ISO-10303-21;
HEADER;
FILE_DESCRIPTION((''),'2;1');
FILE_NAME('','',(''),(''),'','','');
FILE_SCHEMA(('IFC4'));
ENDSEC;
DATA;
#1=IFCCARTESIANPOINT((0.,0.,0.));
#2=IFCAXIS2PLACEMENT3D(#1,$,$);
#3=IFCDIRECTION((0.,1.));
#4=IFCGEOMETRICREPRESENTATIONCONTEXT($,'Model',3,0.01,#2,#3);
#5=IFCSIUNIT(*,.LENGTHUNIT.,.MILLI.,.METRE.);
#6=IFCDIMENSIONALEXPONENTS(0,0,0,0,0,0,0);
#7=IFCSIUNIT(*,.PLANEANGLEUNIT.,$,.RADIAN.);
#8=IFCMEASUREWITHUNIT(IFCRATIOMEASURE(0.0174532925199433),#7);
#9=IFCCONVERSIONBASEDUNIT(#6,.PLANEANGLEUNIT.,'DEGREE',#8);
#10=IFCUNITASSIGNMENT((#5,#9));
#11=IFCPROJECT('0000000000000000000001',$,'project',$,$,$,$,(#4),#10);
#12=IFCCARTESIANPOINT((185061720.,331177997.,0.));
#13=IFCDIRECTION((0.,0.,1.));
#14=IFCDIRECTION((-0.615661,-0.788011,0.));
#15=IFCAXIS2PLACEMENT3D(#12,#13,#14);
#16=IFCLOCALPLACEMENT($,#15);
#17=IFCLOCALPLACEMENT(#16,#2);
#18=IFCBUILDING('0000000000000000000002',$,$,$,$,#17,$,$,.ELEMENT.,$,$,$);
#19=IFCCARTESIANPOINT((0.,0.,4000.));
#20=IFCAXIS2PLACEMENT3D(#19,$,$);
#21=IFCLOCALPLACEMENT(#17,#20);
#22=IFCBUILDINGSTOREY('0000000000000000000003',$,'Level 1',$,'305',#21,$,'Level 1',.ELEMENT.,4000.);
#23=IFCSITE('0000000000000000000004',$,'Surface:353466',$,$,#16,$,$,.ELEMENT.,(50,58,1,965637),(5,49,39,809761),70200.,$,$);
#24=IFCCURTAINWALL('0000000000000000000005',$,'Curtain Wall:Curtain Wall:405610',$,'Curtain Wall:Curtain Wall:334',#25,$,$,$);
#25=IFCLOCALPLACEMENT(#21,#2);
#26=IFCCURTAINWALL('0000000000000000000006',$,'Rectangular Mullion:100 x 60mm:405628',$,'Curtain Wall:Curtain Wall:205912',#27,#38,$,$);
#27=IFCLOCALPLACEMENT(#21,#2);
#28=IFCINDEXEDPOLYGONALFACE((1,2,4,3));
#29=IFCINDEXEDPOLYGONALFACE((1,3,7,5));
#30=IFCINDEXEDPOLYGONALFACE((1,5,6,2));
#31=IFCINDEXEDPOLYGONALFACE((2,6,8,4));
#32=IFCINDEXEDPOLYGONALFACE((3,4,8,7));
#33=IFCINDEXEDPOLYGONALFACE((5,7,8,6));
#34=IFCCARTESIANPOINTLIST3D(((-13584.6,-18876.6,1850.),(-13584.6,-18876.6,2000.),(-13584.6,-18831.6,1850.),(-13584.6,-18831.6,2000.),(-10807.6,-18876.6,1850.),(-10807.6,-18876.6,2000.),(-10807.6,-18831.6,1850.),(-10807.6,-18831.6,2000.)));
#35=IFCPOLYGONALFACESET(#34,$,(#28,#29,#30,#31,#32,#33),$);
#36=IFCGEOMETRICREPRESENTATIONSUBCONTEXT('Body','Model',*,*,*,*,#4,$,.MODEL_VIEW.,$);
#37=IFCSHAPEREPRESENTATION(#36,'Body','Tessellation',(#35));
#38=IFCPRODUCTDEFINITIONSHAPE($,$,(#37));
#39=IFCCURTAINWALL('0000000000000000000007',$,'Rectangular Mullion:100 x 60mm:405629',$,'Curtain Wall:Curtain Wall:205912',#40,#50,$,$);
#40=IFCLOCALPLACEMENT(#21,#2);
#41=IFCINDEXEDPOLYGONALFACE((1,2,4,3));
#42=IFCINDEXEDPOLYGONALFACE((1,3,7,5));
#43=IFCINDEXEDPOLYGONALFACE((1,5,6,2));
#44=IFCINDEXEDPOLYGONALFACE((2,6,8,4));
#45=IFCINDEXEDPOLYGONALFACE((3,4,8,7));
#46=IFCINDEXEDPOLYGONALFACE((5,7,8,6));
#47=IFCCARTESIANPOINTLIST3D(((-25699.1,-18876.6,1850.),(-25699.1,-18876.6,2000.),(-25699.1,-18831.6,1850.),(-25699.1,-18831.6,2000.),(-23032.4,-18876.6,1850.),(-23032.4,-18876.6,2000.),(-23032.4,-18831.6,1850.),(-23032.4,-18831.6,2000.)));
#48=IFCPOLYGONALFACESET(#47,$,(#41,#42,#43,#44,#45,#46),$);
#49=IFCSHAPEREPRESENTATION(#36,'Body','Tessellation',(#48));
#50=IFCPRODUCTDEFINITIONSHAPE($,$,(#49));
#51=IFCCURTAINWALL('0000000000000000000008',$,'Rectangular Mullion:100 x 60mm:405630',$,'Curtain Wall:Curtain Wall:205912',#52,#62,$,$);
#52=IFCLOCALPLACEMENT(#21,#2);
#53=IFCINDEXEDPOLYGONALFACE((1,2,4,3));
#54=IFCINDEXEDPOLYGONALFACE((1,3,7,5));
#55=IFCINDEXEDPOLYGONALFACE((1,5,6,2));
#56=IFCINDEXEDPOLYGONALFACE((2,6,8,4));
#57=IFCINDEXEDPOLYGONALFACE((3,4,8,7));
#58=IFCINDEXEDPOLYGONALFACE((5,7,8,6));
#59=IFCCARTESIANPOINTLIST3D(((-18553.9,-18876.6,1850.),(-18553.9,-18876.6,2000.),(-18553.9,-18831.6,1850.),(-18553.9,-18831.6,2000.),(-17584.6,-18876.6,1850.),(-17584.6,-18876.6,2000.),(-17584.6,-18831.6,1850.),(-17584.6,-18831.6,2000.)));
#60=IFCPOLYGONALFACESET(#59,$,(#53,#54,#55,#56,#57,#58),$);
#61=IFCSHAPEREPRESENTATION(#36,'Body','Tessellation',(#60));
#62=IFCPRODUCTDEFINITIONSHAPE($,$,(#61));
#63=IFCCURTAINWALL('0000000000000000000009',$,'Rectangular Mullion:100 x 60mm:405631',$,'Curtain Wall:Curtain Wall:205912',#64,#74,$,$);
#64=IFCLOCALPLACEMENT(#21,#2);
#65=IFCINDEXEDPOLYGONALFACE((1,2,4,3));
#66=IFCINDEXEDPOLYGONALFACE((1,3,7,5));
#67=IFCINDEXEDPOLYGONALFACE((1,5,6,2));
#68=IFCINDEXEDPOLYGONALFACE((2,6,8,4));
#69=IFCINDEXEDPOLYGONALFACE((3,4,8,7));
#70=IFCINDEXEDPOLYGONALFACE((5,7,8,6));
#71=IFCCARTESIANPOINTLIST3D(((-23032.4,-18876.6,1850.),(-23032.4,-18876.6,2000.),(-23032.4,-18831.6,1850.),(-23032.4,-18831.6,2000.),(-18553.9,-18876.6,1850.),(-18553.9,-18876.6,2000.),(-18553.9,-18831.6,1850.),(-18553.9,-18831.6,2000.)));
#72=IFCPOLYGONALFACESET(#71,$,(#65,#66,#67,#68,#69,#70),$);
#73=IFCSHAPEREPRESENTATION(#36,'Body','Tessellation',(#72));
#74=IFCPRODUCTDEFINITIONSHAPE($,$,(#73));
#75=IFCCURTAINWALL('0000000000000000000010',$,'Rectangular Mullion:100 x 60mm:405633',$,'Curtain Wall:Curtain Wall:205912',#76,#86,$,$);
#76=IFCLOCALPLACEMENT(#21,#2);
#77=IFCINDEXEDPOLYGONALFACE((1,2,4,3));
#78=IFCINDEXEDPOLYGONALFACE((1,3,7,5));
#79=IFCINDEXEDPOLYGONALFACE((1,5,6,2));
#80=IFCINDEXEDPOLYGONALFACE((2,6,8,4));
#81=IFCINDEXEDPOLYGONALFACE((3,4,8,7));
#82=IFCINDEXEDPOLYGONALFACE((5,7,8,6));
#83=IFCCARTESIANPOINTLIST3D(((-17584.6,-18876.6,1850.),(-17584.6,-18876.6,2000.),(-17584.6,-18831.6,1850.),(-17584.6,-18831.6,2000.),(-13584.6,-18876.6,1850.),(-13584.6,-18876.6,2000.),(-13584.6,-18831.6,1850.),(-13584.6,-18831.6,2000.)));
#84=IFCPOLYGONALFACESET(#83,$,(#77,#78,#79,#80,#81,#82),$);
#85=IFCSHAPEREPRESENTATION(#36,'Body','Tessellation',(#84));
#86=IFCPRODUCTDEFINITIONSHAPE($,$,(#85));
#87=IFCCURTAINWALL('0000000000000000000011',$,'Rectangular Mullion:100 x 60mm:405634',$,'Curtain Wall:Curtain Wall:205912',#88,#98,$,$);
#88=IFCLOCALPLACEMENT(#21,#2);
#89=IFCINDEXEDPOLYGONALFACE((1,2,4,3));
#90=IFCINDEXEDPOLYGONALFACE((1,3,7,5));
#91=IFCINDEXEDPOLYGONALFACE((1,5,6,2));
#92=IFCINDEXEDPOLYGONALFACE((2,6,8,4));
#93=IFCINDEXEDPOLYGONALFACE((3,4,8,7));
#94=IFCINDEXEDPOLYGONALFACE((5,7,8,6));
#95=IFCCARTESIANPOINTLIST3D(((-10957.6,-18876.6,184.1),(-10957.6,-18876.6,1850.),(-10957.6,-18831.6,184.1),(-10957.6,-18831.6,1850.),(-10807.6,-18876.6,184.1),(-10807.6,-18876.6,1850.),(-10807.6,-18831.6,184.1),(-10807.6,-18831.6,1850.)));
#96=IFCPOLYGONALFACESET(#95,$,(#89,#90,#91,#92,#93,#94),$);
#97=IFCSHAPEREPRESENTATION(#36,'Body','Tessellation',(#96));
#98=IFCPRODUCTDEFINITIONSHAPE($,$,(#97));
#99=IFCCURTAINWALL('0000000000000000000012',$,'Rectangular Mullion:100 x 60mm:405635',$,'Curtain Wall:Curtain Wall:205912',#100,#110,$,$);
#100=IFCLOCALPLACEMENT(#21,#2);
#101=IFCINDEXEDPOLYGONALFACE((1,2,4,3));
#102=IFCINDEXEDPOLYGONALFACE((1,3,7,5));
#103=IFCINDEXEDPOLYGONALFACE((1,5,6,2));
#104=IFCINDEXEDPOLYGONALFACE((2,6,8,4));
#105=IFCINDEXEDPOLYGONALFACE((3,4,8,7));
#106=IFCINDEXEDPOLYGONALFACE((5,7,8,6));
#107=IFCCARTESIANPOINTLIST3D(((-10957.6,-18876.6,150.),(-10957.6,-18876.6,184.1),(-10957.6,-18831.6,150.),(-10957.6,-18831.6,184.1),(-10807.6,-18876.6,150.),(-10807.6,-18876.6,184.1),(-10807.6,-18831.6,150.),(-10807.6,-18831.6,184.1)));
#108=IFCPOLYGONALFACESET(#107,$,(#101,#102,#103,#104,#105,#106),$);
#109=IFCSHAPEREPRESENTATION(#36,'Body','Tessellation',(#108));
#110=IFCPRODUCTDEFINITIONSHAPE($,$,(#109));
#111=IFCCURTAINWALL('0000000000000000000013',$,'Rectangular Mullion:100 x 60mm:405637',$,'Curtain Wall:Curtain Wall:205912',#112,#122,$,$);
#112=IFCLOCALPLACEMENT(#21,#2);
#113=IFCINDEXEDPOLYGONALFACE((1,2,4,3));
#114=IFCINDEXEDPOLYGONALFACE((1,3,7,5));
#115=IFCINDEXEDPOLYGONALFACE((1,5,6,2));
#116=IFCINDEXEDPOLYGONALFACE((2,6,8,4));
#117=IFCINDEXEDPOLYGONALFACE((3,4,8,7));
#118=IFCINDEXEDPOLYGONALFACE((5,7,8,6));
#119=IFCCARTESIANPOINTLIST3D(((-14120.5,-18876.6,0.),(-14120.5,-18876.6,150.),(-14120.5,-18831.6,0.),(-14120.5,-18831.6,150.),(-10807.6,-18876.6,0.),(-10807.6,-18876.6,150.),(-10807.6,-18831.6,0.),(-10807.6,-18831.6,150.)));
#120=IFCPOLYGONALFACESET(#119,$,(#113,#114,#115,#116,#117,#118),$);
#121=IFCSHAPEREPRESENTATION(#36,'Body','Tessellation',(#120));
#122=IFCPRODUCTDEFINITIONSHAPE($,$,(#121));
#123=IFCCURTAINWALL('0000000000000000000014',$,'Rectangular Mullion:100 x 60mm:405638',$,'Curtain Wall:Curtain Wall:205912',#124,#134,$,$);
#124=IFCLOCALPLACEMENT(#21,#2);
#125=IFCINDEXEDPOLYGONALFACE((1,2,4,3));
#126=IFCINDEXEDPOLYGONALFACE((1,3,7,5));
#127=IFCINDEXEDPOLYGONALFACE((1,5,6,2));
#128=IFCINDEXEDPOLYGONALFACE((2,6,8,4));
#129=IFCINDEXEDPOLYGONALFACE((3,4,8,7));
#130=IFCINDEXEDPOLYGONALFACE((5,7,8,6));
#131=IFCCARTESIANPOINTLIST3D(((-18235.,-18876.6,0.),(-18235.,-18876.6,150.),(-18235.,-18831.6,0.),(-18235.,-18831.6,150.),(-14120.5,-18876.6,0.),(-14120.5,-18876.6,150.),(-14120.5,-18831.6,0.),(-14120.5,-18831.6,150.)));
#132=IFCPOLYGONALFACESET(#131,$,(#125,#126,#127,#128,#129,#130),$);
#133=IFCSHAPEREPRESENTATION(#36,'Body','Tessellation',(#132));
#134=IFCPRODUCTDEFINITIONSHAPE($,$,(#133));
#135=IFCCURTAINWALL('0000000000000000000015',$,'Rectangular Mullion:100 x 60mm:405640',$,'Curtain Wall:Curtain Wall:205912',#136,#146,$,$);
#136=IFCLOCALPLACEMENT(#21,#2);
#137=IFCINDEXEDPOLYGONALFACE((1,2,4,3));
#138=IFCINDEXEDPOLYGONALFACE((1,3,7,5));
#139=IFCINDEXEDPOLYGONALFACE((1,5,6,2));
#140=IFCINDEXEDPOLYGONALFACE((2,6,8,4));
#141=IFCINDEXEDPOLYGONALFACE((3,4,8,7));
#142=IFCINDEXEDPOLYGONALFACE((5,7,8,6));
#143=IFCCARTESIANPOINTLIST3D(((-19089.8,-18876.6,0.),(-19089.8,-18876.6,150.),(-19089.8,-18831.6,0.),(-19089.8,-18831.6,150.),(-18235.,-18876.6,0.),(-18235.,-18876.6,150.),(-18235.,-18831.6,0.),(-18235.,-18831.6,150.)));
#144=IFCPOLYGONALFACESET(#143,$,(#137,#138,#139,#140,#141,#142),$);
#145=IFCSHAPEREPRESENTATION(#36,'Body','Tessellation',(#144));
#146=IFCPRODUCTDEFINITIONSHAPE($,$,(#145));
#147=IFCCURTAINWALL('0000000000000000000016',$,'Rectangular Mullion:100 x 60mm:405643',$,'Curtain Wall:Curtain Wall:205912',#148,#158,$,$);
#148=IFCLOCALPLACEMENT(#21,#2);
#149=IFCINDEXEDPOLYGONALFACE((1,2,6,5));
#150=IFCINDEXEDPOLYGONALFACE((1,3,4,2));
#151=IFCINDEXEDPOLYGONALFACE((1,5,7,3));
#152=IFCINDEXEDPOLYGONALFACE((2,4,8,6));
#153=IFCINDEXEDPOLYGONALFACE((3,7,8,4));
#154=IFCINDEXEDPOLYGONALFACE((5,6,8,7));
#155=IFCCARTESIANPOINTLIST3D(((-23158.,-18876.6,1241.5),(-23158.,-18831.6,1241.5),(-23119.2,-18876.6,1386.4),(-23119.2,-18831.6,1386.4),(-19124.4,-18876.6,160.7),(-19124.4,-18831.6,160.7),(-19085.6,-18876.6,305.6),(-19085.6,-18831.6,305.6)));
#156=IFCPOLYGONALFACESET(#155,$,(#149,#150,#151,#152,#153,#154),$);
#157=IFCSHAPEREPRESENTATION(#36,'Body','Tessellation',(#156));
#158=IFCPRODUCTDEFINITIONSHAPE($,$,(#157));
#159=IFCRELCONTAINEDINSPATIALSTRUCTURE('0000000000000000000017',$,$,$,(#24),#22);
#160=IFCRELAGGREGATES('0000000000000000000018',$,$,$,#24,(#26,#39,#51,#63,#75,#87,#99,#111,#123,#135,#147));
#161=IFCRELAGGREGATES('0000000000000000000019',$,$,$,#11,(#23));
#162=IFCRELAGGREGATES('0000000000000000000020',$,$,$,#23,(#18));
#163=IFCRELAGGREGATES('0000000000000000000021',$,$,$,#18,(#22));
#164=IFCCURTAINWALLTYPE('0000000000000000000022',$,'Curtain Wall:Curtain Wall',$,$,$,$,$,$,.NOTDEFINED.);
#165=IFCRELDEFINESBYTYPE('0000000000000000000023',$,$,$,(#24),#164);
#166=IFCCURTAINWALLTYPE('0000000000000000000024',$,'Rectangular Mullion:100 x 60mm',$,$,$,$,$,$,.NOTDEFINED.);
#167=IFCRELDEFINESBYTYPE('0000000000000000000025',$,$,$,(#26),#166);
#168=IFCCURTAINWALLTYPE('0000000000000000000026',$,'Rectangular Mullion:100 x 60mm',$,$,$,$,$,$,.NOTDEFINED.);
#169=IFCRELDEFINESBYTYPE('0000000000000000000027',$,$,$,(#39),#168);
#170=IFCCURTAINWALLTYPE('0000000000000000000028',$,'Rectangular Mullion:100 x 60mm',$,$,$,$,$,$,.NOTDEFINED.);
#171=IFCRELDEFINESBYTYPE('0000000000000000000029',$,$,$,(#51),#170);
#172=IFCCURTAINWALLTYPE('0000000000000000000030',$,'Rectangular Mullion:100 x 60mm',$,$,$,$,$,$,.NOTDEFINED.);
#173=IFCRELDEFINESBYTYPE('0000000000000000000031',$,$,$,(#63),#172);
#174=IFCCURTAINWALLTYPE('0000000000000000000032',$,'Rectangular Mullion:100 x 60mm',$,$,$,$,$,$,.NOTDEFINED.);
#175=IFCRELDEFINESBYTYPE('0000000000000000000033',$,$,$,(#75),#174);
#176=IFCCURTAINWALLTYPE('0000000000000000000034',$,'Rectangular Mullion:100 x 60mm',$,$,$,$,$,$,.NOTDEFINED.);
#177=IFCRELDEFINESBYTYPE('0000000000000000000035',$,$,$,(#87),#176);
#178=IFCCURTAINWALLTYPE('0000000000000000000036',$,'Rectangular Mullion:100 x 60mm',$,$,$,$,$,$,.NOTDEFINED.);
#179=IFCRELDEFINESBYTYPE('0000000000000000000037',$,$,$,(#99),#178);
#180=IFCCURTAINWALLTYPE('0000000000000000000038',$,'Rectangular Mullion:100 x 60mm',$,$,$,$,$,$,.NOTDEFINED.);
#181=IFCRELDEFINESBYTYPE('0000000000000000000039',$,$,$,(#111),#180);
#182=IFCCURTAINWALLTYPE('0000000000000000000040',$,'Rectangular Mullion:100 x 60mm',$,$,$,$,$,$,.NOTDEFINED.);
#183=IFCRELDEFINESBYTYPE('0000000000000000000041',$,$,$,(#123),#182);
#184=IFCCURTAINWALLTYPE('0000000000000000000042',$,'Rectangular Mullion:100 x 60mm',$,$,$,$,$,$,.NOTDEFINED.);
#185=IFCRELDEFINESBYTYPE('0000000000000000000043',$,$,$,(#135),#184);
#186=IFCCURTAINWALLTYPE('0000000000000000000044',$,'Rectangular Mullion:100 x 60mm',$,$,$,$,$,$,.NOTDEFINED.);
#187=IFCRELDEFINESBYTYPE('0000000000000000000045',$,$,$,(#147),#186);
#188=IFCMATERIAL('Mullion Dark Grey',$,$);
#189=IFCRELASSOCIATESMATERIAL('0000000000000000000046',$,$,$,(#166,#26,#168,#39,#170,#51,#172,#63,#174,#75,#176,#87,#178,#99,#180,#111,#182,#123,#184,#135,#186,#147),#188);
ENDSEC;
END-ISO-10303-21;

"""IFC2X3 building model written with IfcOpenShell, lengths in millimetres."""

from ifc_helpers import new_model, entity, si_unit, converted_unit, direction, frame, frame_2d, origin, place, context, subcontext, project, spatial, rectangle, extrude, source, transform, mapped, material, type_object, type_shapes, element, aggregate, save


model = new_model("IFC2X3")

# Units and contexts
model_context = context("Model", 3, precision=0.01, world=origin(), true_north=direction((0.0, 1.0)))
body_context = subcontext(model_context, "Body", "Model", "MODEL_VIEW")
ifc_project = project(units=[si_unit("LENGTHUNIT", "METRE", prefix="MILLI"), converted_unit("PLANEANGLEUNIT", "DEGREE", entity("IfcRatioMeasure", 0.0174532925199433), si_unit("PLANEANGLEUNIT", "RADIAN"), dimensions=[0, 0, 0, 0, 0, 0, 0])], contexts=[model_context])

# Site, building, storey
site_placement = place(None, frame((185061720.0, 331177997.0, 0.0), z_axis=(0.0, 0.0, 1.0), x_axis=(-0.615661, -0.788011, 0.0)))
site = spatial("IfcSite", under=ifc_project, at=site_placement, Name="Surface:353466", CompositionType="ELEMENT", RefLatitude=(50, 58, 1, 965637), RefLongitude=(5, 49, 39, 809761), RefElevation=70200.0)
building_placement = place(site_placement, origin())
building = spatial("IfcBuilding", under=site, at=building_placement, CompositionType="ELEMENT")
storey_placement = place(building_placement, frame((0.0, 0.0, 4000.0)))
storey = spatial("IfcBuildingStorey", under=building, at=storey_placement, Name="Level 1", ObjectType="305", LongName="Level 1", CompositionType="ELEMENT", Elevation=4000.0)

# Curtain walls
curtain_wall_type_1 = type_object("IfcCurtainWallType", Name="Curtain Wall:Curtain Wall", PredefinedType="NOTDEFINED")
curtain_wall_1_placement = place(storey_placement, frame((0.0, 0.0, -4000.0)))
curtain_wall_1 = element("IfcCurtainWall", 1, at=curtain_wall_1_placement, inside=storey, type_object=curtain_wall_type_1, Name="Curtain Wall:Curtain Wall:405610", ObjectType="Curtain Wall:Curtain Wall:334")
ifc_material_1 = material(Name="Mullion Dark Grey")
curtain_wall_type_2 = type_object("IfcCurtainWallType", Name="Rectangular Mullion:100 x 60mm", PredefinedType="NOTDEFINED", material=ifc_material_1)
shared_shape_1 = source(origin(), body_context, "Body", "SweptSolid", [
    extrude(rectangle(XDim=150.0, YDim=45.0, at=frame_2d((0.0, 0.0), x_axis=(1.0, 0.0))), frame((-75.0, -7.5, -2777.0)), (0.0, 0.0, 1.0), 2777.0),
])
type_shapes(curtain_wall_type_2, [shared_shape_1])
curtain_wall_2_placement = place(storey_placement, frame((-10807.6, -18861.6, 2000.0), z_axis=(1.0, 0.0, 0.0), x_axis=(0.0, 0.0, 1.0)))
curtain_wall_2 = element("IfcCurtainWall", 2, at=curtain_wall_2_placement, type_object=curtain_wall_type_2, material=ifc_material_1, Name="Rectangular Mullion:100 x 60mm:405628", ObjectType="Curtain Wall:Curtain Wall:205912", context=body_context, shape_type="MappedRepresentation", body=[
    mapped(shared_shape_1, transform((0.0, 0.0, 0.0), scale=1.0)),
])
curtain_wall_type_3 = type_object("IfcCurtainWallType", Name="Rectangular Mullion:100 x 60mm", PredefinedType="NOTDEFINED", material=ifc_material_1)
shared_shape_2 = source(origin(), body_context, "Body", "SweptSolid", [
    extrude(rectangle(XDim=150.0, YDim=45.0, at=frame_2d((0.0, 0.0), x_axis=(1.0, 0.0))), frame((-75.0, -7.5, -2666.7)), (0.0, 0.0, 1.0), 2666.7),
])
type_shapes(curtain_wall_type_3, [shared_shape_2])
curtain_wall_3_placement = place(storey_placement, frame((-23032.4, -18861.6, 2000.0), z_axis=(1.0, 0.0, 0.0), x_axis=(0.0, 0.0, 1.0)))
curtain_wall_3 = element("IfcCurtainWall", 3, at=curtain_wall_3_placement, type_object=curtain_wall_type_3, material=ifc_material_1, Name="Rectangular Mullion:100 x 60mm:405629", ObjectType="Curtain Wall:Curtain Wall:205912", context=body_context, shape_type="MappedRepresentation", body=[
    mapped(shared_shape_2, transform((0.0, 0.0, 0.0), scale=1.0)),
])
curtain_wall_type_4 = type_object("IfcCurtainWallType", Name="Rectangular Mullion:100 x 60mm", PredefinedType="NOTDEFINED", material=ifc_material_1)
shared_shape_3 = source(origin(), body_context, "Body", "SweptSolid", [
    extrude(rectangle(XDim=150.0, YDim=45.0, at=frame_2d((0.0, 0.0), x_axis=(1.0, 0.0))), frame((-75.0, -7.5, -969.3)), (0.0, 0.0, 1.0), 969.3),
])
type_shapes(curtain_wall_type_4, [shared_shape_3])
curtain_wall_4_placement = place(storey_placement, frame((-17584.6, -18861.6, 2000.0), z_axis=(1.0, 0.0, 0.0), x_axis=(0.0, 0.0, 1.0)))
curtain_wall_4 = element("IfcCurtainWall", 4, at=curtain_wall_4_placement, type_object=curtain_wall_type_4, material=ifc_material_1, Name="Rectangular Mullion:100 x 60mm:405630", ObjectType="Curtain Wall:Curtain Wall:205912", context=body_context, shape_type="MappedRepresentation", body=[
    mapped(shared_shape_3, transform((0.0, 0.0, 0.0), scale=1.0)),
])
curtain_wall_type_5 = type_object("IfcCurtainWallType", Name="Rectangular Mullion:100 x 60mm", PredefinedType="NOTDEFINED", material=ifc_material_1)
shared_shape_4 = source(origin(), body_context, "Body", "SweptSolid", [
    extrude(rectangle(XDim=150.0, YDim=45.0, at=frame_2d((0.0, 0.0), x_axis=(1.0, 0.0))), frame((-75.0, -7.5, -4478.5)), (0.0, 0.0, 1.0), 4478.5),
])
type_shapes(curtain_wall_type_5, [shared_shape_4])
curtain_wall_5_placement = place(storey_placement, frame((-18553.9, -18861.6, 2000.0), z_axis=(1.0, 0.0, 0.0), x_axis=(0.0, 0.0, 1.0)))
curtain_wall_5 = element("IfcCurtainWall", 5, at=curtain_wall_5_placement, type_object=curtain_wall_type_5, material=ifc_material_1, Name="Rectangular Mullion:100 x 60mm:405631", ObjectType="Curtain Wall:Curtain Wall:205912", context=body_context, shape_type="MappedRepresentation", body=[
    mapped(shared_shape_4, transform((0.0, 0.0, 0.0), scale=1.0)),
])
curtain_wall_type_6 = type_object("IfcCurtainWallType", Name="Rectangular Mullion:100 x 60mm", PredefinedType="NOTDEFINED", material=ifc_material_1)
shared_shape_5 = source(origin(), body_context, "Body", "SweptSolid", [
    extrude(rectangle(XDim=150.0, YDim=45.0, at=frame_2d((0.0, 0.0), x_axis=(1.0, 0.0))), frame((-75.0, -7.5, -4000.0)), (0.0, 0.0, 1.0), 4000.0),
])
type_shapes(curtain_wall_type_6, [shared_shape_5])
curtain_wall_6_placement = place(storey_placement, frame((-13584.6, -18861.6, 2000.0), z_axis=(1.0, 0.0, 0.0), x_axis=(0.0, 0.0, 1.0)))
curtain_wall_6 = element("IfcCurtainWall", 6, at=curtain_wall_6_placement, type_object=curtain_wall_type_6, material=ifc_material_1, Name="Rectangular Mullion:100 x 60mm:405633", ObjectType="Curtain Wall:Curtain Wall:205912", context=body_context, shape_type="MappedRepresentation", body=[
    mapped(shared_shape_5, transform((0.0, 0.0, 0.0), scale=1.0)),
])
curtain_wall_type_7 = type_object("IfcCurtainWallType", Name="Rectangular Mullion:100 x 60mm", PredefinedType="NOTDEFINED", material=ifc_material_1)
shared_shape_6 = source(origin(), body_context, "Body", "SweptSolid", [
    extrude(rectangle(XDim=150.0, YDim=45.0, at=frame_2d((0.0, 0.0), x_axis=(1.0, 0.0))), frame((-75.0, -7.5, -1665.9)), (0.0, 0.0, 1.0), 1665.9),
])
type_shapes(curtain_wall_type_7, [shared_shape_6])
curtain_wall_7_placement = place(storey_placement, frame((-10807.6, -18861.6, 184.1), z_axis=(0.0, 0.0, -1.0), x_axis=(1.0, 0.0, 0.0)))
curtain_wall_7 = element("IfcCurtainWall", 7, at=curtain_wall_7_placement, type_object=curtain_wall_type_7, material=ifc_material_1, Name="Rectangular Mullion:100 x 60mm:405634", ObjectType="Curtain Wall:Curtain Wall:205912", context=body_context, shape_type="MappedRepresentation", body=[
    mapped(shared_shape_6, transform((0.0, 0.0, 0.0), scale=1.0)),
])
curtain_wall_type_8 = type_object("IfcCurtainWallType", Name="Rectangular Mullion:100 x 60mm", PredefinedType="NOTDEFINED", material=ifc_material_1)
shared_shape_7 = source(origin(), body_context, "Body", "SweptSolid", [
    extrude(rectangle(XDim=150.0, YDim=45.0, at=frame_2d((0.0, 0.0), x_axis=(1.0, 0.0))), frame((-75.0, -7.5, -34.1)), (0.0, 0.0, 1.0), 34.1),
])
type_shapes(curtain_wall_type_8, [shared_shape_7])
curtain_wall_8_placement = place(storey_placement, frame((-10807.6, -18861.6, 150.0), z_axis=(0.0, 0.0, -1.0), x_axis=(1.0, 0.0, 0.0)))
curtain_wall_8 = element("IfcCurtainWall", 8, at=curtain_wall_8_placement, type_object=curtain_wall_type_8, material=ifc_material_1, Name="Rectangular Mullion:100 x 60mm:405635", ObjectType="Curtain Wall:Curtain Wall:205912", context=body_context, shape_type="MappedRepresentation", body=[
    mapped(shared_shape_7, transform((0.0, 0.0, 0.0), scale=1.0)),
])
curtain_wall_type_9 = type_object("IfcCurtainWallType", Name="Rectangular Mullion:100 x 60mm", PredefinedType="NOTDEFINED", material=ifc_material_1)
shared_shape_8 = source(origin(), body_context, "Body", "SweptSolid", [
    extrude(rectangle(XDim=45.0, YDim=150.0, at=frame_2d((0.0, 0.0), x_axis=(1.0, 0.0))), frame((-75.0, -7.5, -3312.9), z_axis=(0.0, 0.0, 1.0), x_axis=(0.0, 1.0, 0.0)), (0.0, 0.0, 1.0), 3312.9),
])
type_shapes(curtain_wall_type_9, [shared_shape_8])
curtain_wall_9_placement = place(storey_placement, frame((-14120.5, -18861.6, 0.0), z_axis=(-1.0, 0.0, 0.0), x_axis=(0.0, 0.0, -1.0)))
curtain_wall_9 = element("IfcCurtainWall", 9, at=curtain_wall_9_placement, type_object=curtain_wall_type_9, material=ifc_material_1, Name="Rectangular Mullion:100 x 60mm:405637", ObjectType="Curtain Wall:Curtain Wall:205912", context=body_context, shape_type="MappedRepresentation", body=[
    mapped(shared_shape_8, transform((0.0, 0.0, 0.0), scale=1.0)),
])
curtain_wall_type_10 = type_object("IfcCurtainWallType", Name="Rectangular Mullion:100 x 60mm", PredefinedType="NOTDEFINED", material=ifc_material_1)
shared_shape_9 = source(origin(), body_context, "Body", "SweptSolid", [
    extrude(rectangle(XDim=45.0, YDim=150.0, at=frame_2d((0.0, 0.0), x_axis=(1.0, 0.0))), frame((-75.0, -7.5, -4114.5), z_axis=(0.0, 0.0, 1.0), x_axis=(0.0, 1.0, 0.0)), (0.0, 0.0, 1.0), 4114.5),
])
type_shapes(curtain_wall_type_10, [shared_shape_9])
curtain_wall_10_placement = place(storey_placement, frame((-18235.0, -18861.6, 0.0), z_axis=(-1.0, 0.0, 0.0), x_axis=(0.0, 0.0, -1.0)))
curtain_wall_10 = element("IfcCurtainWall", 10, at=curtain_wall_10_placement, type_object=curtain_wall_type_10, material=ifc_material_1, Name="Rectangular Mullion:100 x 60mm:405638", ObjectType="Curtain Wall:Curtain Wall:205912", context=body_context, shape_type="MappedRepresentation", body=[
    mapped(shared_shape_9, transform((0.0, 0.0, 0.0), scale=1.0)),
])
curtain_wall_type_11 = type_object("IfcCurtainWallType", Name="Rectangular Mullion:100 x 60mm", PredefinedType="NOTDEFINED", material=ifc_material_1)
shared_shape_10 = source(origin(), body_context, "Body", "SweptSolid", [
    extrude(rectangle(XDim=45.0, YDim=150.0, at=frame_2d((0.0, 0.0), x_axis=(1.0, 0.0))), frame((-75.0, -7.5, -854.8), z_axis=(0.0, 0.0, 1.0), x_axis=(0.0, 1.0, 0.0)), (0.0, 0.0, 1.0), 854.8),
])
type_shapes(curtain_wall_type_11, [shared_shape_10])
curtain_wall_11_placement = place(storey_placement, frame((-19089.8, -18861.6, 0.0), z_axis=(-1.0, 0.0, 0.0), x_axis=(0.0, 0.0, -1.0)))
curtain_wall_11 = element("IfcCurtainWall", 11, at=curtain_wall_11_placement, type_object=curtain_wall_type_11, material=ifc_material_1, Name="Rectangular Mullion:100 x 60mm:405640", ObjectType="Curtain Wall:Curtain Wall:205912", context=body_context, shape_type="MappedRepresentation", body=[
    mapped(shared_shape_10, transform((0.0, 0.0, 0.0), scale=1.0)),
])
curtain_wall_type_12 = type_object("IfcCurtainWallType", Name="Rectangular Mullion:100 x 60mm", PredefinedType="NOTDEFINED", material=ifc_material_1)
shared_shape_11 = source(origin(), body_context, "Body", "SweptSolid", [
    extrude(rectangle(XDim=150.0, YDim=45.0, at=frame_2d((0.0, 0.0), x_axis=(1.0, 0.0))), frame((0.0, -7.5, -4175.9)), (0.0, 0.0, 1.0), 4175.9),
])
type_shapes(curtain_wall_type_12, [shared_shape_11])
curtain_wall_12_placement = place(storey_placement, frame((-19105.0, -18861.6, 233.1), z_axis=(0.965926, 0.0, -0.258819), x_axis=(0.258819, 0.0, 0.965926)))
curtain_wall_12 = element("IfcCurtainWall", 12, at=curtain_wall_12_placement, type_object=curtain_wall_type_12, material=ifc_material_1, Name="Rectangular Mullion:100 x 60mm:405643", ObjectType="Curtain Wall:Curtain Wall:205912", context=body_context, shape_type="MappedRepresentation", body=[
    mapped(shared_shape_11, transform((0.0, 0.0, 0.0), scale=1.0)),
])
aggregate(curtain_wall_1, [curtain_wall_2, curtain_wall_3, curtain_wall_4, curtain_wall_5, curtain_wall_6, curtain_wall_7, curtain_wall_8, curtain_wall_9, curtain_wall_10, curtain_wall_11, curtain_wall_12])

save(model, "model.ifc")
